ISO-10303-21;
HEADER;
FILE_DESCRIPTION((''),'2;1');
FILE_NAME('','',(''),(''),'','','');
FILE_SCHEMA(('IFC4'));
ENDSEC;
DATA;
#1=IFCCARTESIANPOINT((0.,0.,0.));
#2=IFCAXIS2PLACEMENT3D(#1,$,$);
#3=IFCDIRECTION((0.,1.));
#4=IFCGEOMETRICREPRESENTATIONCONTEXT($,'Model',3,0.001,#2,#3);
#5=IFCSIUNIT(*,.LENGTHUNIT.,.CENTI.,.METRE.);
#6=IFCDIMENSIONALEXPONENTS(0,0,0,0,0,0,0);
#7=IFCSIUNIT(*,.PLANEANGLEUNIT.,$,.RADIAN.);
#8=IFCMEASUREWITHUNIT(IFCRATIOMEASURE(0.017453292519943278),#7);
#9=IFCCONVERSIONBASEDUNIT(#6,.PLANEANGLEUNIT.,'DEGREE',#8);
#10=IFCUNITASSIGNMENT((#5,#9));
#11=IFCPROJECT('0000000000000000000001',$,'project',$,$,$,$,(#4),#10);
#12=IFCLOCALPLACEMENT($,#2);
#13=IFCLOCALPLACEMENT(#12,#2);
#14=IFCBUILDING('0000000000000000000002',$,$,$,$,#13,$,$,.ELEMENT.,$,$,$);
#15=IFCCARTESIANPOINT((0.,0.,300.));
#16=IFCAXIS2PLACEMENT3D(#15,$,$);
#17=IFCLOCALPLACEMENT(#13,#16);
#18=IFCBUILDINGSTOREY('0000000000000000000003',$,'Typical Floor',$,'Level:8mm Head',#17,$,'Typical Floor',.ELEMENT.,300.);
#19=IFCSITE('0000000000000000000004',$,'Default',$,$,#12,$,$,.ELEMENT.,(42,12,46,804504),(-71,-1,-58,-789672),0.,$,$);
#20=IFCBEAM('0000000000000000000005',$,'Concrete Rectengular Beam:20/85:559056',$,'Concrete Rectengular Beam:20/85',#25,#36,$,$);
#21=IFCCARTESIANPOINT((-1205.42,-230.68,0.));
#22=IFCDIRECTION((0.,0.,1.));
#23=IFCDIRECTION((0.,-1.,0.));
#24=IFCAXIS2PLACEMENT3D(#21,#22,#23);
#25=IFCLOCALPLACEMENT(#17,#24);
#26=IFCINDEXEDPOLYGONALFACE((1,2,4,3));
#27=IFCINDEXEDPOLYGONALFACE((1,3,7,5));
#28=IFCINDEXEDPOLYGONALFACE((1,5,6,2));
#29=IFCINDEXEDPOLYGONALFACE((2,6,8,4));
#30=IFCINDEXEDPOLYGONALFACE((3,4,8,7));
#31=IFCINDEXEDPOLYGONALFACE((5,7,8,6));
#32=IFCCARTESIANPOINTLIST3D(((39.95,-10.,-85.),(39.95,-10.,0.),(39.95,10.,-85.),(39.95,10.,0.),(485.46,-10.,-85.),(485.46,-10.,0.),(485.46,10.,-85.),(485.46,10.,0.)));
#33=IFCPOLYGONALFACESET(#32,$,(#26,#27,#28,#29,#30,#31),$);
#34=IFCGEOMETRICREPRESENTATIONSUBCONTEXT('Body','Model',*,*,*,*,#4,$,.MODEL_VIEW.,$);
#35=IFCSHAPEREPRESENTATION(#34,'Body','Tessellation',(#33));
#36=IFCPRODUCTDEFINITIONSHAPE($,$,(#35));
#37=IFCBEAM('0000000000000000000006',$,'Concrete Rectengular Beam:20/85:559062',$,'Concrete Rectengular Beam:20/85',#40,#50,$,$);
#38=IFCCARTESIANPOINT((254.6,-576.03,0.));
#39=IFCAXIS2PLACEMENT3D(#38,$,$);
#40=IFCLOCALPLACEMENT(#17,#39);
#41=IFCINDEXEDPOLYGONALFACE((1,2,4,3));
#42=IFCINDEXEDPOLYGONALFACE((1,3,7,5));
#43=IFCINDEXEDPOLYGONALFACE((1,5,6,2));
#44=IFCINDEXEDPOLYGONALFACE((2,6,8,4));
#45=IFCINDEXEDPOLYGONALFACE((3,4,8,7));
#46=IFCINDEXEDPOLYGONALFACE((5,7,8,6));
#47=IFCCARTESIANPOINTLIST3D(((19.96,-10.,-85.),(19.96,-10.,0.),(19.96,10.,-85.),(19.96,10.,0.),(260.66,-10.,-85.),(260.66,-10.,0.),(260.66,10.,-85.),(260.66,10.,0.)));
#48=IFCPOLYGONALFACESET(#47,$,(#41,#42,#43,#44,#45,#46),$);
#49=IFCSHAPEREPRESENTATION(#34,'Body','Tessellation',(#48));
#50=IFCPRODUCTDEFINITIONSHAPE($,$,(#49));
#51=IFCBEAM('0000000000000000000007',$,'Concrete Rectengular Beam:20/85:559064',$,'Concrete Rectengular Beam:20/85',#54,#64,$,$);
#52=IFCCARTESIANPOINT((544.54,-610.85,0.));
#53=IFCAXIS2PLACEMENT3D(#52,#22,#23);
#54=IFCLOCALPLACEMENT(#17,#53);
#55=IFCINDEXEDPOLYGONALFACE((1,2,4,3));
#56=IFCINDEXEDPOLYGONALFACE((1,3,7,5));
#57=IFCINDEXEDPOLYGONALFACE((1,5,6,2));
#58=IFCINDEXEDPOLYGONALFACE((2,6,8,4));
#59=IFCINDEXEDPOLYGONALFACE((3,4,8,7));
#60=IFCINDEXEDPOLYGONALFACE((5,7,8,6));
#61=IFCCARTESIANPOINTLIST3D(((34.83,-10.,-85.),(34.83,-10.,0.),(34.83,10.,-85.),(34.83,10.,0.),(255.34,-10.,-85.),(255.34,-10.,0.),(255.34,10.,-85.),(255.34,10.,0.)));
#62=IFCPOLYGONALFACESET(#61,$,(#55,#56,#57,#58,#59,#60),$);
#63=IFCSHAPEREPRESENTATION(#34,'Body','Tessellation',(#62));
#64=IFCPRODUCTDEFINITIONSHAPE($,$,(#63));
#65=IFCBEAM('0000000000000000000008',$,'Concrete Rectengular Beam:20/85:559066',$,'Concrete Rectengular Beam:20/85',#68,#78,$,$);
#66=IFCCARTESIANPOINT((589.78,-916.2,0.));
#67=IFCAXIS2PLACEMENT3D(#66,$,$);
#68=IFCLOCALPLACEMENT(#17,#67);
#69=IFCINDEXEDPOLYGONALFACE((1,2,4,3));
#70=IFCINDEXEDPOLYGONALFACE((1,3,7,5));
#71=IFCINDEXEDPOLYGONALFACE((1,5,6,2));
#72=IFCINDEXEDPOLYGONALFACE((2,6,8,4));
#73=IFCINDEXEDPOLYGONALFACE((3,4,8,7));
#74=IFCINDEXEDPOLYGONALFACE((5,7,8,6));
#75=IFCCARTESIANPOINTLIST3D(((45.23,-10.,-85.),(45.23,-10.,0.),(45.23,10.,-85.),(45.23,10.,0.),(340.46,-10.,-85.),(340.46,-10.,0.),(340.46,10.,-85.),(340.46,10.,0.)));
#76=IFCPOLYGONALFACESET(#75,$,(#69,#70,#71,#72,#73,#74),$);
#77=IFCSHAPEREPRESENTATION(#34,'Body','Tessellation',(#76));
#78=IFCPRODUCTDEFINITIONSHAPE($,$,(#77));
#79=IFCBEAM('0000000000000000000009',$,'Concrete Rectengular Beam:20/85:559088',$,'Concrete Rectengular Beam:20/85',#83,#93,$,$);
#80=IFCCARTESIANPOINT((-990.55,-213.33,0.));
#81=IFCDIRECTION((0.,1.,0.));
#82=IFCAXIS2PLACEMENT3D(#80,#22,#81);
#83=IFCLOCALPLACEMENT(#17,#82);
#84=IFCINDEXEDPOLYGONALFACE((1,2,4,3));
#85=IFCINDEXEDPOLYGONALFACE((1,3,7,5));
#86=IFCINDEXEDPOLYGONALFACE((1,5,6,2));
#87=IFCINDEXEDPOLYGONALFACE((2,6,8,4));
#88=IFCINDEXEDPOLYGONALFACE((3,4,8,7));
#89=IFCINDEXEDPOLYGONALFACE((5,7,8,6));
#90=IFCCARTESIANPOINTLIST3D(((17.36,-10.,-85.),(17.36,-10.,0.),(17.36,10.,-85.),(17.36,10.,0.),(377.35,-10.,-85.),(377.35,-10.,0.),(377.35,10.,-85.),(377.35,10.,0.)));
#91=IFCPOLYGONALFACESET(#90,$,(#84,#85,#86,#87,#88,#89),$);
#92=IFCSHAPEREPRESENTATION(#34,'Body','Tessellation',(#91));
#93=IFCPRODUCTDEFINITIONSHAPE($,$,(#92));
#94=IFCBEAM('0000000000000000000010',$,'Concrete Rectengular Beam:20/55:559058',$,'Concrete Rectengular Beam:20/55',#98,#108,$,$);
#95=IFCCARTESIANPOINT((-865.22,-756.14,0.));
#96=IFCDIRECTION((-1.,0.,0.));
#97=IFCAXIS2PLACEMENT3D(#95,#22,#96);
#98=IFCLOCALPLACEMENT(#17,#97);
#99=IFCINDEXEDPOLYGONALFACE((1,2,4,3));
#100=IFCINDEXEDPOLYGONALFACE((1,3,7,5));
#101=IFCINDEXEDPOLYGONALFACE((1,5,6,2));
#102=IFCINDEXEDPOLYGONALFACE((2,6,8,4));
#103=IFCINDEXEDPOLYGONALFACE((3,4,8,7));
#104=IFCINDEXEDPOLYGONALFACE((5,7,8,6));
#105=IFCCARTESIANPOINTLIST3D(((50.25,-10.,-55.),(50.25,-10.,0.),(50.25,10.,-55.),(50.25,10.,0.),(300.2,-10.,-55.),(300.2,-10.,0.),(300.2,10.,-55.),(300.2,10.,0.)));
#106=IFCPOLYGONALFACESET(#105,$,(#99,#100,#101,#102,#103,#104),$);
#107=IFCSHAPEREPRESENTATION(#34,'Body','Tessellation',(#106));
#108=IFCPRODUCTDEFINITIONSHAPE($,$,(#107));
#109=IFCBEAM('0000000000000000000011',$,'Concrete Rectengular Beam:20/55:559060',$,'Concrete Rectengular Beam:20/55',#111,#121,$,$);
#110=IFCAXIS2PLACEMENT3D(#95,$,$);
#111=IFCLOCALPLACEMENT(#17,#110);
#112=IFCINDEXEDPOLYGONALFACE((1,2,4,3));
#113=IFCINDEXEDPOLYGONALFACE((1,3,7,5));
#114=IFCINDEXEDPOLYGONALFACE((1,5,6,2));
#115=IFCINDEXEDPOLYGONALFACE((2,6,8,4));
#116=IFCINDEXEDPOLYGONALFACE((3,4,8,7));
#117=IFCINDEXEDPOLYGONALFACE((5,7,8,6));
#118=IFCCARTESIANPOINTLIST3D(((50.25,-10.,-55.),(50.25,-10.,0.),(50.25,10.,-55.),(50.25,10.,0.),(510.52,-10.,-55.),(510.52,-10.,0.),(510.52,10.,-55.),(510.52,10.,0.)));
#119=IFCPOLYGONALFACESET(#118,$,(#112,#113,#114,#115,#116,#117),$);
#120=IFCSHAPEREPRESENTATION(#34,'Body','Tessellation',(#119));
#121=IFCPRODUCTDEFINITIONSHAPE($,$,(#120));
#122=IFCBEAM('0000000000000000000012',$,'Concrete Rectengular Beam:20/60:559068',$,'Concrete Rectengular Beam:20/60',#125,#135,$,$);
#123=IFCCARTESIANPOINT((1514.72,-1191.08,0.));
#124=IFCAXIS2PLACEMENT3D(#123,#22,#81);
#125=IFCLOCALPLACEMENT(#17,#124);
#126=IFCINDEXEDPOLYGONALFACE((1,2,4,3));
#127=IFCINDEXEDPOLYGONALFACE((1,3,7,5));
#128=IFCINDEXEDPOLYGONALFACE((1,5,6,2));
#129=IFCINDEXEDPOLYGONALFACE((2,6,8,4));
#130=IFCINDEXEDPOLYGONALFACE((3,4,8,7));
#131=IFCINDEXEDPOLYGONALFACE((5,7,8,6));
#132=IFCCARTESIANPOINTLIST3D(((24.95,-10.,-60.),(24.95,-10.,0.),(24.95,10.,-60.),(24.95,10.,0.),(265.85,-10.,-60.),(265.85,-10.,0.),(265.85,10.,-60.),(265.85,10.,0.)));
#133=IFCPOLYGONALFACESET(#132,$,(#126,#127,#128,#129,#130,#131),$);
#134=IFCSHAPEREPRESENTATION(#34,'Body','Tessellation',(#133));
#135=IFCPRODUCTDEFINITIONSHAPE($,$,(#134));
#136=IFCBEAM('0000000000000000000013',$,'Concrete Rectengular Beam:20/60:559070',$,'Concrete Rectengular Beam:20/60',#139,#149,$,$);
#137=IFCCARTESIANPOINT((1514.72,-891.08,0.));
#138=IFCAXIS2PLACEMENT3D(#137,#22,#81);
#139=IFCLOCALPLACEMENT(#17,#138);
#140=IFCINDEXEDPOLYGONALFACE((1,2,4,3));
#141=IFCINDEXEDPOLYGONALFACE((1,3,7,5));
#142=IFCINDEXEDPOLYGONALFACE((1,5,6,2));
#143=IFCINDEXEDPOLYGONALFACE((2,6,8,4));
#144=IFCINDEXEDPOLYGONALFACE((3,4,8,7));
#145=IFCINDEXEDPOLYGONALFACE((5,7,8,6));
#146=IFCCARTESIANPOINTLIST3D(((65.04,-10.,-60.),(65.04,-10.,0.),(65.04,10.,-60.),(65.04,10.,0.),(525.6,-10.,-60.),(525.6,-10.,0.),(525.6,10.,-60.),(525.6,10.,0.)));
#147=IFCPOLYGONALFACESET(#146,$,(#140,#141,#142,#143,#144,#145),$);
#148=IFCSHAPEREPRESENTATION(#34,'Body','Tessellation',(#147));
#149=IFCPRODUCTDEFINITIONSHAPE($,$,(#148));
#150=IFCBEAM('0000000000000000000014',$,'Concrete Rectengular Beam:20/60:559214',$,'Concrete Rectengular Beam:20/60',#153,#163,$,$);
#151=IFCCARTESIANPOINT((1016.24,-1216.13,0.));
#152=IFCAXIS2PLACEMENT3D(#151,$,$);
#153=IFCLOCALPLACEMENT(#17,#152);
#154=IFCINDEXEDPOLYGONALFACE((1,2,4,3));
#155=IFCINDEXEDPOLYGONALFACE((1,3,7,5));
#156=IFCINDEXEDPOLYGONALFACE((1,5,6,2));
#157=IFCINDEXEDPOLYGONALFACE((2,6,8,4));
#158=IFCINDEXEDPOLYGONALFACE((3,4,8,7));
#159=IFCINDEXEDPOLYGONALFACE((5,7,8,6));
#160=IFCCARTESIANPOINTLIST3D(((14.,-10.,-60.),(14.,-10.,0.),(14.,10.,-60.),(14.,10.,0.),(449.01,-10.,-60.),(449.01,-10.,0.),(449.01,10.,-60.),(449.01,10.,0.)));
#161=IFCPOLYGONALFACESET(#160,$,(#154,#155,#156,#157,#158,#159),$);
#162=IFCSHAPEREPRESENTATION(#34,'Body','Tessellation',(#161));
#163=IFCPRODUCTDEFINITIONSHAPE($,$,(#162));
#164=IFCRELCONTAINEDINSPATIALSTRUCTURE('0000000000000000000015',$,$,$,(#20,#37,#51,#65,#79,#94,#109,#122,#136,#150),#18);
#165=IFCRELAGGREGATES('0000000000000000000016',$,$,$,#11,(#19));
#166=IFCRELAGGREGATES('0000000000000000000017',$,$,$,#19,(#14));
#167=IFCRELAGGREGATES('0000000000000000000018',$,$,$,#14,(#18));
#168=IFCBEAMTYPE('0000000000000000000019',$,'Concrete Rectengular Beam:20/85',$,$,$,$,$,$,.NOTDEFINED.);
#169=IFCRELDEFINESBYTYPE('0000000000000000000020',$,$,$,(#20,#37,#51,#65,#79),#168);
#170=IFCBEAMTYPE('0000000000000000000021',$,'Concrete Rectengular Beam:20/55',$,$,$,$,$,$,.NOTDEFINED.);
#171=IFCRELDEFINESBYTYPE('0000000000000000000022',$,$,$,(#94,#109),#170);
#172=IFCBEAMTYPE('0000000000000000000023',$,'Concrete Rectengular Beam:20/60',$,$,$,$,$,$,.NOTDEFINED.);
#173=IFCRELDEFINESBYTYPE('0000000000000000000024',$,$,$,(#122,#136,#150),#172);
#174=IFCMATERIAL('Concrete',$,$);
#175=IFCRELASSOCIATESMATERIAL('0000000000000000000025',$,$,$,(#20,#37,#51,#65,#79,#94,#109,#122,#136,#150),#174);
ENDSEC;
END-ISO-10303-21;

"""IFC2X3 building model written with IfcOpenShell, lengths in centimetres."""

from ifc_helpers import new_model, entity, si_unit, converted_unit, direction, frame, frame_2d, origin, origin_2d_with_axis, place, context, subcontext, project, spatial, rectangle, extrude, material, type_object, element, save


model = new_model("IFC2X3")

# Units and contexts
model_context = context("Model", 3, precision=0.001, world=origin(), true_north=direction((0.0, 1.0)))
body_context = subcontext(model_context, "Body", "Model", "MODEL_VIEW")
ifc_project = project(units=[si_unit("LENGTHUNIT", "METRE", prefix="CENTI"), converted_unit("PLANEANGLEUNIT", "DEGREE", entity("IfcRatioMeasure", 0.017453292519943278), si_unit("PLANEANGLEUNIT", "RADIAN"), dimensions=[0, 0, 0, 0, 0, 0, 0])], contexts=[model_context])

# Site, building, storey
site_placement = place(None, origin())
site = spatial("IfcSite", under=ifc_project, at=site_placement, Name="Default", CompositionType="ELEMENT", RefLatitude=(42, 12, 46, 804504), RefLongitude=(-71, -1, -58, -789672), RefElevation=0.0)
building_placement = place(site_placement, origin())
building = spatial("IfcBuilding", under=site, at=building_placement, CompositionType="ELEMENT")
storey_placement = place(building_placement, frame((0.0, 0.0, 300.0)))
storey = spatial("IfcBuildingStorey", under=building, at=storey_placement, Name="Typical Floor", ObjectType="Level:8mm Head", LongName="Typical Floor", CompositionType="ELEMENT", Elevation=300.0)

# Beams
ifc_material = material(Name="Concrete")
beam_type_1 = type_object("IfcBeamType", Name="Concrete Rectengular Beam:20/85", PredefinedType="NOTDEFINED")
beam_1_placement = place(storey_placement, frame((-1205.42, -230.68, 0.0), z_axis=(0.0, 0.0, 1.0), x_axis=(0.0, -1.0, 0.0)))
element("IfcBeam", 1, at=beam_1_placement, inside=storey, type_object=beam_type_1, material=ifc_material, Name="Concrete Rectengular Beam:20/85:559056", ObjectType="Concrete Rectengular Beam:20/85", context=body_context, shape_type="SweptSolid", body=[
    extrude(rectangle(XDim=85.0, YDim=20.0, at=frame_2d((0.0, 0.0), x_axis=(1.0, 0.0))), frame((39.95, 0.0, -42.5), z_axis=(1.0, 0.0, 0.0), x_axis=(0.0, 0.0, -1.0)), (0.0, 0.0, 1.0), 445.5),
])
beam_2_placement = place(storey_placement, frame((254.6, -576.03, 0.0)))
element("IfcBeam", 2, at=beam_2_placement, inside=storey, type_object=beam_type_1, material=ifc_material, Name="Concrete Rectengular Beam:20/85:559062", ObjectType="Concrete Rectengular Beam:20/85", context=body_context, shape_type="SweptSolid", body=[
    extrude(rectangle(XDim=85.0, YDim=20.0, at=frame_2d((0.0, 0.0), x_axis=(1.0, 0.0))), frame((19.96, 0.0, -42.5), z_axis=(1.0, 0.0, 0.0), x_axis=(0.0, 0.0, -1.0)), (0.0, 0.0, 1.0), 240.7),
])
beam_3_placement = place(storey_placement, frame((544.54, -610.85, 0.0), z_axis=(0.0, 0.0, 1.0), x_axis=(0.0, -1.0, 0.0)))
element("IfcBeam", 3, at=beam_3_placement, inside=storey, type_object=beam_type_1, material=ifc_material, Name="Concrete Rectengular Beam:20/85:559064", ObjectType="Concrete Rectengular Beam:20/85", context=body_context, shape_type="SweptSolid", body=[
    extrude(rectangle(XDim=85.0, YDim=20.0, at=frame_2d((0.0, 0.0), x_axis=(1.0, 0.0))), frame((34.83, 0.0, -42.5), z_axis=(1.0, 0.0, 0.0), x_axis=(0.0, 0.0, -1.0)), (0.0, 0.0, 1.0), 220.51),
])
beam_4_placement = place(storey_placement, frame((589.78, -916.2, 0.0)))
element("IfcBeam", 4, at=beam_4_placement, inside=storey, type_object=beam_type_1, material=ifc_material, Name="Concrete Rectengular Beam:20/85:559066", ObjectType="Concrete Rectengular Beam:20/85", context=body_context, shape_type="SweptSolid", body=[
    extrude(rectangle(XDim=85.0, YDim=20.0, at=frame_2d((0.0, 0.0), x_axis=(1.0, 0.0))), frame((45.23, 0.0, -42.5), z_axis=(1.0, 0.0, 0.0), x_axis=(0.0, 0.0, -1.0)), (0.0, 0.0, 1.0), 295.23),
])
beam_5_placement = place(storey_placement, frame((-990.55, -213.33, 0.0), z_axis=(0.0, 0.0, 1.0), x_axis=(0.0, 1.0, 0.0)))
element("IfcBeam", 5, at=beam_5_placement, inside=storey, type_object=beam_type_1, material=ifc_material, Name="Concrete Rectengular Beam:20/85:559088", ObjectType="Concrete Rectengular Beam:20/85", context=body_context, shape_type="SweptSolid", body=[
    extrude(rectangle(XDim=85.0, YDim=20.0, at=frame_2d((0.0, 0.0), x_axis=(1.0, 0.0))), frame((17.36, 0.0, -42.5), z_axis=(1.0, 0.0, 0.0), x_axis=(0.0, 0.0, -1.0)), (0.0, 0.0, 1.0), 359.99),
])
beam_type_2 = type_object("IfcBeamType", Name="Concrete Rectengular Beam:20/55", PredefinedType="NOTDEFINED")
beam_6_placement = place(storey_placement, frame((-865.22, -756.14, 0.0), z_axis=(0.0, 0.0, 1.0), x_axis=(-1.0, 0.0, 0.0)))
element("IfcBeam", 6, at=beam_6_placement, inside=storey, type_object=beam_type_2, material=ifc_material, Name="Concrete Rectengular Beam:20/55:559058", ObjectType="Concrete Rectengular Beam:20/55", context=body_context, shape_type="SweptSolid", body=[
    extrude(rectangle(XDim=55.0, YDim=20.0, at=frame_2d((0.0, 0.0), x_axis=(1.0, 0.0))), frame((50.25, 0.0, -27.5), z_axis=(1.0, 0.0, 0.0), x_axis=(0.0, 0.0, -1.0)), (0.0, 0.0, 1.0), 249.95),
])
beam_7_placement = place(storey_placement, frame((-865.22, -756.14, 0.0)))
element("IfcBeam", 7, at=beam_7_placement, inside=storey, type_object=beam_type_2, material=ifc_material, Name="Concrete Rectengular Beam:20/55:559060", ObjectType="Concrete Rectengular Beam:20/55", context=body_context, shape_type="SweptSolid", body=[
    extrude(rectangle(XDim=55.0, YDim=20.0, at=frame_2d((0.0, 0.0), x_axis=(1.0, 0.0))), frame((50.25, 0.0, -27.5), z_axis=(1.0, 0.0, 0.0), x_axis=(0.0, 0.0, -1.0)), (0.0, 0.0, 1.0), 460.27),
])
beam_type_3 = type_object("IfcBeamType", Name="Concrete Rectengular Beam:20/60", PredefinedType="NOTDEFINED")
beam_8_placement = place(storey_placement, frame((1514.72, -1191.08, 0.0), z_axis=(0.0, 0.0, 1.0), x_axis=(0.0, 1.0, 0.0)))
element("IfcBeam", 8, at=beam_8_placement, inside=storey, type_object=beam_type_3, material=ifc_material, Name="Concrete Rectengular Beam:20/60:559068", ObjectType="Concrete Rectengular Beam:20/60", context=body_context, shape_type="SweptSolid", body=[
    extrude(rectangle(XDim=60.0, YDim=20.0, at=frame_2d((0.0, 0.0), x_axis=(1.0, 0.0))), frame((24.95, 0.0, -30.0), z_axis=(1.0, 0.0, 0.0), x_axis=(0.0, 0.0, -1.0)), (0.0, 0.0, 1.0), 240.9),
])
beam_9_placement = place(storey_placement, frame((1514.72, -891.08, 0.0), z_axis=(0.0, 0.0, 1.0), x_axis=(0.0, 1.0, 0.0)))
element("IfcBeam", 9, at=beam_9_placement, inside=storey, type_object=beam_type_3, material=ifc_material, Name="Concrete Rectengular Beam:20/60:559070", ObjectType="Concrete Rectengular Beam:20/60", context=body_context, shape_type="SweptSolid", body=[
    extrude(rectangle(XDim=60.0, YDim=20.0, at=origin_2d_with_axis()), frame((65.04, 0.0, -30.0), z_axis=(1.0, 0.0, 0.0), x_axis=(0.0, 0.0, -1.0)), (0.0, 0.0, 1.0), 460.56),
])
beam_10_placement = place(storey_placement, frame((1016.24, -1216.13, 0.0)))
element("IfcBeam", 10, at=beam_10_placement, inside=storey, type_object=beam_type_3, material=ifc_material, Name="Concrete Rectengular Beam:20/60:559214", ObjectType="Concrete Rectengular Beam:20/60", context=body_context, shape_type="SweptSolid", body=[
    extrude(rectangle(XDim=60.0, YDim=20.0, at=frame_2d((0.0, 0.0), x_axis=(1.0, 0.0))), frame((14.0, 0.0, -30.0), z_axis=(1.0, 0.0, 0.0), x_axis=(0.0, 0.0, -1.0)), (0.0, 0.0, 1.0), 435.01),
])

save(model, "model.ifc")
